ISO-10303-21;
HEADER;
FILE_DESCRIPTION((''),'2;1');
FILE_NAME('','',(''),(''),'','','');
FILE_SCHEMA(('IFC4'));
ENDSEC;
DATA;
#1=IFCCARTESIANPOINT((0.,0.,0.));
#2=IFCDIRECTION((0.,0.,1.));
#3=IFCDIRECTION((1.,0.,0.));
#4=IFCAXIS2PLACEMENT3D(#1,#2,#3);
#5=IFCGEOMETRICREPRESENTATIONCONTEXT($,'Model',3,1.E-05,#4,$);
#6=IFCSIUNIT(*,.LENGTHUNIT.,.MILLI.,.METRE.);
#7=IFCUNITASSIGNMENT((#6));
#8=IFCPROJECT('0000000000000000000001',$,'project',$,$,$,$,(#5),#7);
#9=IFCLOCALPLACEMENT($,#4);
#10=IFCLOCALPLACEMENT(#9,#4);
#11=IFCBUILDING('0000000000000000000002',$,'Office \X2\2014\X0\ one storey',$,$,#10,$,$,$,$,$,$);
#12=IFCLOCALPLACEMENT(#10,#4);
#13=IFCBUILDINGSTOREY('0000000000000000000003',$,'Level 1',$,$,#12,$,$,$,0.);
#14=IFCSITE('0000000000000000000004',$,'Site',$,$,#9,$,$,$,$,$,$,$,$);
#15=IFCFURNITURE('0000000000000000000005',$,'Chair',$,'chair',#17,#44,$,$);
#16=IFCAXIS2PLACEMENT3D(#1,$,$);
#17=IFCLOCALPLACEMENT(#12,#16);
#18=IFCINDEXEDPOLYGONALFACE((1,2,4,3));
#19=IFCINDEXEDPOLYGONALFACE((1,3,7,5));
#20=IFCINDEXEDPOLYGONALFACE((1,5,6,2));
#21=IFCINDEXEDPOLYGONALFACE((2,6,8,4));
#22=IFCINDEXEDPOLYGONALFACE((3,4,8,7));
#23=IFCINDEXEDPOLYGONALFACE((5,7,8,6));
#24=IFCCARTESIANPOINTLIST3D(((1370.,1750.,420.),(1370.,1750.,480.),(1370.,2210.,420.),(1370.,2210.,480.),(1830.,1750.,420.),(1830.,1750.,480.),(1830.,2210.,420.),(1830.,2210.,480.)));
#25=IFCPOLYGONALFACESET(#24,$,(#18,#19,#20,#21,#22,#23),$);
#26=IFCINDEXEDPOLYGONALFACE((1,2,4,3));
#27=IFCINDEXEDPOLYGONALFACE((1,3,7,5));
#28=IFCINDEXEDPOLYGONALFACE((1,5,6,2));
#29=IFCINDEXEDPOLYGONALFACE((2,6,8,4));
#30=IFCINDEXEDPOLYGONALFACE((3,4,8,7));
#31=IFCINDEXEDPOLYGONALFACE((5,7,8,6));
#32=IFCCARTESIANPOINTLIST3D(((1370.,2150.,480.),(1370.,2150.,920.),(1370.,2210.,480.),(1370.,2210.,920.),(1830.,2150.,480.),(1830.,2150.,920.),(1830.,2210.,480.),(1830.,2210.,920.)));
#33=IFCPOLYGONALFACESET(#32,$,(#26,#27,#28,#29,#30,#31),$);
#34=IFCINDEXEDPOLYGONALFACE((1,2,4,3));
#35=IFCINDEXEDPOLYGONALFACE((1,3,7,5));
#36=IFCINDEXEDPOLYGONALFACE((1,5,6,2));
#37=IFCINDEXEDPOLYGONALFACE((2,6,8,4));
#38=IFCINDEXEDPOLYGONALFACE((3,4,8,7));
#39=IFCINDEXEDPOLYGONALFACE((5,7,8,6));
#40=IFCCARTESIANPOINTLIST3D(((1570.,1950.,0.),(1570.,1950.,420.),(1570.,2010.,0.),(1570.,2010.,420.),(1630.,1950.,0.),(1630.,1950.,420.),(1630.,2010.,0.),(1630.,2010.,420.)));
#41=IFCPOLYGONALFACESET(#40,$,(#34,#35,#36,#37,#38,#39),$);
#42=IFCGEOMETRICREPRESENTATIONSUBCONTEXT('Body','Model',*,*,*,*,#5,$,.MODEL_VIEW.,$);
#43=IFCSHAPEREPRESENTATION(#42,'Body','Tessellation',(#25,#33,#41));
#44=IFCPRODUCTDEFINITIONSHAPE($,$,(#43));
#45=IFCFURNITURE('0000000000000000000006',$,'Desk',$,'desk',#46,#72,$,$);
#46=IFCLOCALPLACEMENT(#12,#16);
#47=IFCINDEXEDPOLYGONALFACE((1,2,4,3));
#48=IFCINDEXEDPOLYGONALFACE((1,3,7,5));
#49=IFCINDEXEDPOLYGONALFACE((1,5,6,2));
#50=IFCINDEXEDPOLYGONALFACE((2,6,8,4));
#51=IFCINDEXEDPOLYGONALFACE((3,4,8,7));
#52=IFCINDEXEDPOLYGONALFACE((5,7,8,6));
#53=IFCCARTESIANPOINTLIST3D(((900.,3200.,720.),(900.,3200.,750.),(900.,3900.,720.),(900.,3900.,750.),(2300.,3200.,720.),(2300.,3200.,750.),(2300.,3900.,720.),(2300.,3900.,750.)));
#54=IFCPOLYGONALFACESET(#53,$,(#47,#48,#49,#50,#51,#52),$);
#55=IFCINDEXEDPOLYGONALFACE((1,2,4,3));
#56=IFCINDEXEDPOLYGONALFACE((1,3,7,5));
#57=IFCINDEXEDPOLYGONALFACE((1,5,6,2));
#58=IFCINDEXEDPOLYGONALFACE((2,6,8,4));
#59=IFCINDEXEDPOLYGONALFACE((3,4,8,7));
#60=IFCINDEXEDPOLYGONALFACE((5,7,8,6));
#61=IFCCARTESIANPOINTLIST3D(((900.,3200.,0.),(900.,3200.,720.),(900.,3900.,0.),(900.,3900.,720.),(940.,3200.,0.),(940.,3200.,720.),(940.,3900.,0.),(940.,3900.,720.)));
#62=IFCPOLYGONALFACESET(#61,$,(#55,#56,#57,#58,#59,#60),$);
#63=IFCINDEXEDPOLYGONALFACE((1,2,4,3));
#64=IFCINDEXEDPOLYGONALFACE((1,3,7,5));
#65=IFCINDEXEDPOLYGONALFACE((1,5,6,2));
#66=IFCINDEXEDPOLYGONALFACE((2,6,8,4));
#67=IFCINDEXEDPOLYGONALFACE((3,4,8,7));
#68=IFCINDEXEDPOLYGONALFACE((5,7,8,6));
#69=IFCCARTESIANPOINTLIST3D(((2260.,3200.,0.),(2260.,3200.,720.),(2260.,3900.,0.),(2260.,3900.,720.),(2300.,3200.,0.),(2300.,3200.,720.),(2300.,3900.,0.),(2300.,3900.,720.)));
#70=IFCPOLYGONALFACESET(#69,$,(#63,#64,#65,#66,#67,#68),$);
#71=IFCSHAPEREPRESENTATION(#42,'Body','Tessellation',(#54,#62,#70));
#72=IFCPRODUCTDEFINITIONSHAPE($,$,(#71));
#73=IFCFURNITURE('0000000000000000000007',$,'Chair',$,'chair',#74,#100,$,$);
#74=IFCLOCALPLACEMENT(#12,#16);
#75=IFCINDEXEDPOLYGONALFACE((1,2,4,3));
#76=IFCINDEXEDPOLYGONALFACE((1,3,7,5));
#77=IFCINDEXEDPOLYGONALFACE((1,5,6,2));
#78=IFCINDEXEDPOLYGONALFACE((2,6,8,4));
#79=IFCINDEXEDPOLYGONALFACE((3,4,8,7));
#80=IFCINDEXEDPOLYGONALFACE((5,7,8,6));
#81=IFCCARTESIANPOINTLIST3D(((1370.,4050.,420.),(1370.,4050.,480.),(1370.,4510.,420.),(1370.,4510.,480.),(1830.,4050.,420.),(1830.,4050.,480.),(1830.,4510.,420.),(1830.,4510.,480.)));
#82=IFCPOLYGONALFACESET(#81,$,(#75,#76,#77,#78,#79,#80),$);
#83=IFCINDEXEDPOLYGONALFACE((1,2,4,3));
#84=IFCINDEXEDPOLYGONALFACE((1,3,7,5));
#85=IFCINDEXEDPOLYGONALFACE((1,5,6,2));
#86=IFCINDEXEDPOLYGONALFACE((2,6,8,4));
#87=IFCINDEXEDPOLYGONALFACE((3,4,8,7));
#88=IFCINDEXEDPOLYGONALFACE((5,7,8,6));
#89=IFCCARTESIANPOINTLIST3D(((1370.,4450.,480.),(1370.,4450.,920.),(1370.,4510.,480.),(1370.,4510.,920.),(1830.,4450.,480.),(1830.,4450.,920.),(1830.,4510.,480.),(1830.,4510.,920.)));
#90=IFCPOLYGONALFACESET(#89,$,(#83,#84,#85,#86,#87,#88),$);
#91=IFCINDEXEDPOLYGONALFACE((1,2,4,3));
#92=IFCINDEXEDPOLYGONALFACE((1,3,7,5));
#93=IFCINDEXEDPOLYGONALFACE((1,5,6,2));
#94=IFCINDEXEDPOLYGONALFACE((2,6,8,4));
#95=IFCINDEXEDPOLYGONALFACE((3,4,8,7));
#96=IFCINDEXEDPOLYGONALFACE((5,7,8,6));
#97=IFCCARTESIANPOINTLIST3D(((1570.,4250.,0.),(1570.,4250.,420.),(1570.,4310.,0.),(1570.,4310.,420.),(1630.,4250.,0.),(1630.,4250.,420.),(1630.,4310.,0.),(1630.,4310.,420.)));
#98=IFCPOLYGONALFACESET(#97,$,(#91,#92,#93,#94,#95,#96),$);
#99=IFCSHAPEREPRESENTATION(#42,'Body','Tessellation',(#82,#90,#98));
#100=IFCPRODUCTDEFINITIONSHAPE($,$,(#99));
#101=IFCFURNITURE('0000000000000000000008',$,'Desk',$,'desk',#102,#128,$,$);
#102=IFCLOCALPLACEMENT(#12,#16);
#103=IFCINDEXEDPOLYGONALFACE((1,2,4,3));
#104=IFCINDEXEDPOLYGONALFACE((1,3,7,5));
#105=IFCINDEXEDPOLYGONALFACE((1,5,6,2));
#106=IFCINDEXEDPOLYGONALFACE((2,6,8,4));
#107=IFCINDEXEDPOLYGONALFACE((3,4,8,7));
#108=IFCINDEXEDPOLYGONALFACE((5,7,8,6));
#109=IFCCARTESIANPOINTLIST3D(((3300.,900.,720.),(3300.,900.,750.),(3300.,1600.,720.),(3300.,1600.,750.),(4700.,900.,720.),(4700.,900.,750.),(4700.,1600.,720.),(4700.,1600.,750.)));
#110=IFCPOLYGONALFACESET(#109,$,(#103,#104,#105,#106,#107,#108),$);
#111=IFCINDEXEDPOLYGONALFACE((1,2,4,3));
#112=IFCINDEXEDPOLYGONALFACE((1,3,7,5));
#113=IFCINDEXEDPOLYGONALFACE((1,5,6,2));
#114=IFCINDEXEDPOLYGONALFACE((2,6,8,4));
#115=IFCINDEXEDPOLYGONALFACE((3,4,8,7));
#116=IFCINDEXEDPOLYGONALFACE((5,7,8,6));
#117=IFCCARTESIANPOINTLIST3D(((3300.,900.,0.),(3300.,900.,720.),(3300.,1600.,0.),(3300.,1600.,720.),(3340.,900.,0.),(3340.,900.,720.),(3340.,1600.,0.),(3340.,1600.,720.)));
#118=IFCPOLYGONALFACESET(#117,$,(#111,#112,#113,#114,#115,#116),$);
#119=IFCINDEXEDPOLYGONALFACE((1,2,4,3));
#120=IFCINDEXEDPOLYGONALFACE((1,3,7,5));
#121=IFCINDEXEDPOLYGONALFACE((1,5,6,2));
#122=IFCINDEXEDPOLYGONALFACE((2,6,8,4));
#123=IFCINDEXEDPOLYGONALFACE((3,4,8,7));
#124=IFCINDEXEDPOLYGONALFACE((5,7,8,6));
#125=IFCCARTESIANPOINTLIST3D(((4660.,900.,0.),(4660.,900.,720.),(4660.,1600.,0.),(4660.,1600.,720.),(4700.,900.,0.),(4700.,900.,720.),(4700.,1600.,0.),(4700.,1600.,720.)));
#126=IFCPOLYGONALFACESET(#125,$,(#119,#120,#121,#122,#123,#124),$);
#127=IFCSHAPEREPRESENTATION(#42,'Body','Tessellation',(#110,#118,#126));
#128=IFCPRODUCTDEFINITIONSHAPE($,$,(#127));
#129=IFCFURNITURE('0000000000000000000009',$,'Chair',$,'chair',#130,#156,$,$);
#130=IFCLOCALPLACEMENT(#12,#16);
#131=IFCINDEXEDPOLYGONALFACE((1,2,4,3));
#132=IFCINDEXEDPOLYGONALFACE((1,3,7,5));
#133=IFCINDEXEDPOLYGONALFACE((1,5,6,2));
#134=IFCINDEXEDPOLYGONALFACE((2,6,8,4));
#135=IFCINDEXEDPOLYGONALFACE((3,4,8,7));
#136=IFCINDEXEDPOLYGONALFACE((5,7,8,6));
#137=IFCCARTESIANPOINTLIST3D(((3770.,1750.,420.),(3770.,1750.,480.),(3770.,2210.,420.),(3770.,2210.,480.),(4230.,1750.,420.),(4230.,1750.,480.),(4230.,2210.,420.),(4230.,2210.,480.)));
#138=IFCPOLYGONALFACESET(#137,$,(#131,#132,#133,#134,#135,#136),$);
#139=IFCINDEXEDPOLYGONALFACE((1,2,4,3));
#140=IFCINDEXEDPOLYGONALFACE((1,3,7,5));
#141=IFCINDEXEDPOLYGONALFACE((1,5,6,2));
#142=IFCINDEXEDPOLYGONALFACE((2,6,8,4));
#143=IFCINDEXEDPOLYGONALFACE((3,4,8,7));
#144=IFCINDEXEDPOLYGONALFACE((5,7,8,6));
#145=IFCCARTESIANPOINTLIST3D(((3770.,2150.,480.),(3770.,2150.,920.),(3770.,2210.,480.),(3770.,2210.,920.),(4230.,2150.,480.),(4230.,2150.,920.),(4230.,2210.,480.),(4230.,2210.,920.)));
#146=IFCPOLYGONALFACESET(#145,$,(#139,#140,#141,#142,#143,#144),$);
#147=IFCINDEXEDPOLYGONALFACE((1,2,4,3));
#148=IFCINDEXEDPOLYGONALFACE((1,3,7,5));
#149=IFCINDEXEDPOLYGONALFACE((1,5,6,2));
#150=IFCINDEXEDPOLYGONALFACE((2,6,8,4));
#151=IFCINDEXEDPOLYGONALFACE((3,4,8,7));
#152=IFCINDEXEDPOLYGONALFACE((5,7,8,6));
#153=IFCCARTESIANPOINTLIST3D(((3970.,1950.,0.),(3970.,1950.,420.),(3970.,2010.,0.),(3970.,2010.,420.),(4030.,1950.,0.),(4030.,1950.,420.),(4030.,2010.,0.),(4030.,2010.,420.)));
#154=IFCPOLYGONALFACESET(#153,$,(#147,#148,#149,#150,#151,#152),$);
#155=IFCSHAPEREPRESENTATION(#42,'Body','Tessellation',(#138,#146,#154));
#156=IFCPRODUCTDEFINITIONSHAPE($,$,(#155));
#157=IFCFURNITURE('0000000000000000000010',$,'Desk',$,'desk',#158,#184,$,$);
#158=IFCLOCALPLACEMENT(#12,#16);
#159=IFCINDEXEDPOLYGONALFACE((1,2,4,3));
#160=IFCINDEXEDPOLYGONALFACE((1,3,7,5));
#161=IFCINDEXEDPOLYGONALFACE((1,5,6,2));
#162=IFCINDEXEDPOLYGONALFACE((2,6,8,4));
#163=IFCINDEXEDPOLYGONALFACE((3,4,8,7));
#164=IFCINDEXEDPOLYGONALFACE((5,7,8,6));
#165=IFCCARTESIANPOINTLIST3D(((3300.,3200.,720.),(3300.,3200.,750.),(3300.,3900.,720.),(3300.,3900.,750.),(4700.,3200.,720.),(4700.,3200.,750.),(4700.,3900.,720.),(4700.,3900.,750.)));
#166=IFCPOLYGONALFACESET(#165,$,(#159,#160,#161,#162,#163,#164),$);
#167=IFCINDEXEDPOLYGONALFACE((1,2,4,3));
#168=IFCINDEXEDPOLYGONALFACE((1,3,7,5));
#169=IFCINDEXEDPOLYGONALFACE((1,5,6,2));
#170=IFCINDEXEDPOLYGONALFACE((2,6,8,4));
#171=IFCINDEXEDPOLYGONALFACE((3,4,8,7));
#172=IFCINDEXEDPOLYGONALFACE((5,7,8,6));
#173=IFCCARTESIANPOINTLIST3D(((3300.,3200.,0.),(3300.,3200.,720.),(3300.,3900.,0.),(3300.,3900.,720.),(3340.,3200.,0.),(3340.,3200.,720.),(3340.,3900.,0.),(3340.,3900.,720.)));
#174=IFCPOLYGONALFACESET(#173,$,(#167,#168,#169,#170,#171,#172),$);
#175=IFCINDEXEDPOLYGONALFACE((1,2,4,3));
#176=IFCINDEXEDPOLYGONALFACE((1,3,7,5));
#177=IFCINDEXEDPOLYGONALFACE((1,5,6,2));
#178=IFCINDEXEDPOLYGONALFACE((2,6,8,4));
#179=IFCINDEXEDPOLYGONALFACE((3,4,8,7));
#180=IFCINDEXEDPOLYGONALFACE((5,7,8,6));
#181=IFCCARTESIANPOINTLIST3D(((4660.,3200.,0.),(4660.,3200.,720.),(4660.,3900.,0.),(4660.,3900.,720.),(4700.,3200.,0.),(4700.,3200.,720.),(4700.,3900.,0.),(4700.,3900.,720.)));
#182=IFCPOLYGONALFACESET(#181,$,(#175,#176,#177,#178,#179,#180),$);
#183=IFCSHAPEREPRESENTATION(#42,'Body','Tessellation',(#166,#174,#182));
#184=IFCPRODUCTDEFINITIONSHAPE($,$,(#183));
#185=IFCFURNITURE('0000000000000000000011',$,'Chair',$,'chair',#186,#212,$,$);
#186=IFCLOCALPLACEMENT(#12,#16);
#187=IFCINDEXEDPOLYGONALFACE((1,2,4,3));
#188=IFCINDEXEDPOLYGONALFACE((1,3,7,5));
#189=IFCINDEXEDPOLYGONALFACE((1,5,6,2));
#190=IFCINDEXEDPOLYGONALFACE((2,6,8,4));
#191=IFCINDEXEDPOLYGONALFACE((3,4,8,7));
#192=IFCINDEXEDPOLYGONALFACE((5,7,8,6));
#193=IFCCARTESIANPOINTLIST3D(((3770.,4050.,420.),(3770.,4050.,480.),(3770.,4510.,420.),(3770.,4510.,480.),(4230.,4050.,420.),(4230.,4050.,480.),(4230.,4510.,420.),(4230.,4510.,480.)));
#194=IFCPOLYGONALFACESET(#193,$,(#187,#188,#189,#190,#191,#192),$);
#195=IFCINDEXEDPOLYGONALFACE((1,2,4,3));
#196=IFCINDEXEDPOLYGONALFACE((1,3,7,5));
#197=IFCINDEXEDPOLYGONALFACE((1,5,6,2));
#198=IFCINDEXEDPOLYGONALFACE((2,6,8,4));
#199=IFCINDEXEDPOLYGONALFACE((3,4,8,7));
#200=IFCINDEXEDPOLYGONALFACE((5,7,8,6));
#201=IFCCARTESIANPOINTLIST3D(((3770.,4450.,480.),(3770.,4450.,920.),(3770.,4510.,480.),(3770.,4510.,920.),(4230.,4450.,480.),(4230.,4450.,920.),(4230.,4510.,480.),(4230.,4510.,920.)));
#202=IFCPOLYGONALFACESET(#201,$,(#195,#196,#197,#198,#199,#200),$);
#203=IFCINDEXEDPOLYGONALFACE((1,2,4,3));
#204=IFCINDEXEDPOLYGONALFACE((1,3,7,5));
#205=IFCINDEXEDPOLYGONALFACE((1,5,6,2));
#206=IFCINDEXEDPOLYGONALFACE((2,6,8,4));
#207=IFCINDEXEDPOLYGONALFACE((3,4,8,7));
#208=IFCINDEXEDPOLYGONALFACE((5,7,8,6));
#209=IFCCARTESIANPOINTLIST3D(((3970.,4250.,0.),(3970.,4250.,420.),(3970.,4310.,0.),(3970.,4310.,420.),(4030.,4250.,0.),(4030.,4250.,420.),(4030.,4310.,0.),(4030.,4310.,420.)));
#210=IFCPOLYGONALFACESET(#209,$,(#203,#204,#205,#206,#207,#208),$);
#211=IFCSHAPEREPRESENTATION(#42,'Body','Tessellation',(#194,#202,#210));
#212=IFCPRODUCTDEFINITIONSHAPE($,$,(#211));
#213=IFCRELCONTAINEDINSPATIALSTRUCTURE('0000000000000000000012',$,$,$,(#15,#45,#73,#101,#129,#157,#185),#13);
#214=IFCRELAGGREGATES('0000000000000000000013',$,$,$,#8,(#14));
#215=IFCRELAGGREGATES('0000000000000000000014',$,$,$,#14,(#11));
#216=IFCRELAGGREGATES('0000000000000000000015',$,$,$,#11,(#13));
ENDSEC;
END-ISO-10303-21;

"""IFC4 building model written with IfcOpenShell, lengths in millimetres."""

from ifc_helpers import new_model, si_unit, frame, frame_2d, origin, origin_with_axes, place, context, subcontext, project, spatial, rectangle, extrude, element, save


model = new_model("IFC4")

# Units and contexts
model_context = context("Model", 3, precision=1e-05, world=origin_with_axes())
body_context = subcontext(model_context, "Body", "Model", "MODEL_VIEW")
ifc_project = project(units=[si_unit("LENGTHUNIT", "METRE", prefix="MILLI")], contexts=[model_context])

# Site, building, storey
site_placement = place(None, origin_with_axes())
site = spatial("IfcSite", under=ifc_project, at=site_placement, Name="Site")
building_placement = place(site_placement, origin_with_axes())
building = spatial("IfcBuilding", under=site, at=building_placement, Name="Office — one storey")
storey_placement = place(building_placement, origin_with_axes())
storey = spatial("IfcBuildingStorey", under=building, at=storey_placement, Name="Level 1", Elevation=0.0)

# Furniture
furniture_1_placement = place(storey_placement, frame((1370.0, 1750.0, 0.0), z_axis=(0.0, 0.0, 1.0), x_axis=(1.0, 0.0, 0.0)))
element("IfcFurniture", 1, at=furniture_1_placement, inside=storey, Name="Chair", ObjectType="chair", context=body_context, shape_type="SweptSolid", body=[
    extrude(rectangle(XDim=460.0, YDim=460.0, at=frame_2d((230.0, 230.0))), frame((0.0, 0.0, 420.0)), (0.0, 0.0, 1.0), 60.0),
    extrude(rectangle(XDim=460.0, YDim=60.0, at=frame_2d((230.0, 430.0))), frame((0.0, 0.0, 480.0)), (0.0, 0.0, 1.0), 440.0),
    extrude(rectangle(XDim=60.0, YDim=60.0, at=frame_2d((230.0, 230.0))), origin(), (0.0, 0.0, 1.0), 420.0),
])
furniture_2_placement = place(storey_placement, frame((900.0, 3200.0, 0.0), z_axis=(0.0, 0.0, 1.0), x_axis=(1.0, 0.0, 0.0)))
element("IfcFurniture", 2, at=furniture_2_placement, inside=storey, Name="Desk", ObjectType="desk", context=body_context, shape_type="SweptSolid", body=[
    extrude(rectangle(XDim=1400.0, YDim=700.0, at=frame_2d((700.0, 350.0))), frame((0.0, 0.0, 720.0)), (0.0, 0.0, 1.0), 30.0),
    extrude(rectangle(XDim=40.0, YDim=700.0, at=frame_2d((20.0, 350.0))), origin(), (0.0, 0.0, 1.0), 720.0),
    extrude(rectangle(XDim=40.0, YDim=700.0, at=frame_2d((1380.0, 350.0))), origin(), (0.0, 0.0, 1.0), 720.0),
])
furniture_3_placement = place(storey_placement, frame((1370.0, 4050.0, 0.0), z_axis=(0.0, 0.0, 1.0), x_axis=(1.0, 0.0, 0.0)))
element("IfcFurniture", 3, at=furniture_3_placement, inside=storey, Name="Chair", ObjectType="chair", context=body_context, shape_type="SweptSolid", body=[
    extrude(rectangle(XDim=460.0, YDim=460.0, at=frame_2d((230.0, 230.0))), frame((0.0, 0.0, 420.0)), (0.0, 0.0, 1.0), 60.0),
    extrude(rectangle(XDim=460.0, YDim=60.0, at=frame_2d((230.0, 430.0))), frame((0.0, 0.0, 480.0)), (0.0, 0.0, 1.0), 440.0),
    extrude(rectangle(XDim=60.0, YDim=60.0, at=frame_2d((230.0, 230.0))), origin(), (0.0, 0.0, 1.0), 420.0),
])
furniture_4_placement = place(storey_placement, frame((3300.0, 900.0, 0.0), z_axis=(0.0, 0.0, 1.0), x_axis=(1.0, 0.0, 0.0)))
element("IfcFurniture", 4, at=furniture_4_placement, inside=storey, Name="Desk", ObjectType="desk", context=body_context, shape_type="SweptSolid", body=[
    extrude(rectangle(XDim=1400.0, YDim=700.0, at=frame_2d((700.0, 350.0))), frame((0.0, 0.0, 720.0)), (0.0, 0.0, 1.0), 30.0),
    extrude(rectangle(XDim=40.0, YDim=700.0, at=frame_2d((20.0, 350.0))), origin(), (0.0, 0.0, 1.0), 720.0),
    extrude(rectangle(XDim=40.0, YDim=700.0, at=frame_2d((1380.0, 350.0))), origin(), (0.0, 0.0, 1.0), 720.0),
])
furniture_5_placement = place(storey_placement, frame((3770.0, 1750.0, 0.0), z_axis=(0.0, 0.0, 1.0), x_axis=(1.0, 0.0, 0.0)))
element("IfcFurniture", 5, at=furniture_5_placement, inside=storey, Name="Chair", ObjectType="chair", context=body_context, shape_type="SweptSolid", body=[
    extrude(rectangle(XDim=460.0, YDim=460.0, at=frame_2d((230.0, 230.0))), frame((0.0, 0.0, 420.0)), (0.0, 0.0, 1.0), 60.0),
    extrude(rectangle(XDim=460.0, YDim=60.0, at=frame_2d((230.0, 430.0))), frame((0.0, 0.0, 480.0)), (0.0, 0.0, 1.0), 440.0),
    extrude(rectangle(XDim=60.0, YDim=60.0, at=frame_2d((230.0, 230.0))), origin(), (0.0, 0.0, 1.0), 420.0),
])
furniture_6_placement = place(storey_placement, frame((3300.0, 3200.0, 0.0), z_axis=(0.0, 0.0, 1.0), x_axis=(1.0, 0.0, 0.0)))
element("IfcFurniture", 6, at=furniture_6_placement, inside=storey, Name="Desk", ObjectType="desk", context=body_context, shape_type="SweptSolid", body=[
    extrude(rectangle(XDim=1400.0, YDim=700.0, at=frame_2d((700.0, 350.0))), frame((0.0, 0.0, 720.0)), (0.0, 0.0, 1.0), 30.0),
    extrude(rectangle(XDim=40.0, YDim=700.0, at=frame_2d((20.0, 350.0))), origin(), (0.0, 0.0, 1.0), 720.0),
    extrude(rectangle(XDim=40.0, YDim=700.0, at=frame_2d((1380.0, 350.0))), origin(), (0.0, 0.0, 1.0), 720.0),
])
furniture_7_placement = place(storey_placement, frame((3770.0, 4050.0, 0.0), z_axis=(0.0, 0.0, 1.0), x_axis=(1.0, 0.0, 0.0)))
element("IfcFurniture", 7, at=furniture_7_placement, inside=storey, Name="Chair", ObjectType="chair", context=body_context, shape_type="SweptSolid", body=[
    extrude(rectangle(XDim=460.0, YDim=460.0, at=frame_2d((230.0, 230.0))), frame((0.0, 0.0, 420.0)), (0.0, 0.0, 1.0), 60.0),
    extrude(rectangle(XDim=460.0, YDim=60.0, at=frame_2d((230.0, 430.0))), frame((0.0, 0.0, 480.0)), (0.0, 0.0, 1.0), 440.0),
    extrude(rectangle(XDim=60.0, YDim=60.0, at=frame_2d((230.0, 230.0))), origin(), (0.0, 0.0, 1.0), 420.0),
])

save(model, "model.ifc")
